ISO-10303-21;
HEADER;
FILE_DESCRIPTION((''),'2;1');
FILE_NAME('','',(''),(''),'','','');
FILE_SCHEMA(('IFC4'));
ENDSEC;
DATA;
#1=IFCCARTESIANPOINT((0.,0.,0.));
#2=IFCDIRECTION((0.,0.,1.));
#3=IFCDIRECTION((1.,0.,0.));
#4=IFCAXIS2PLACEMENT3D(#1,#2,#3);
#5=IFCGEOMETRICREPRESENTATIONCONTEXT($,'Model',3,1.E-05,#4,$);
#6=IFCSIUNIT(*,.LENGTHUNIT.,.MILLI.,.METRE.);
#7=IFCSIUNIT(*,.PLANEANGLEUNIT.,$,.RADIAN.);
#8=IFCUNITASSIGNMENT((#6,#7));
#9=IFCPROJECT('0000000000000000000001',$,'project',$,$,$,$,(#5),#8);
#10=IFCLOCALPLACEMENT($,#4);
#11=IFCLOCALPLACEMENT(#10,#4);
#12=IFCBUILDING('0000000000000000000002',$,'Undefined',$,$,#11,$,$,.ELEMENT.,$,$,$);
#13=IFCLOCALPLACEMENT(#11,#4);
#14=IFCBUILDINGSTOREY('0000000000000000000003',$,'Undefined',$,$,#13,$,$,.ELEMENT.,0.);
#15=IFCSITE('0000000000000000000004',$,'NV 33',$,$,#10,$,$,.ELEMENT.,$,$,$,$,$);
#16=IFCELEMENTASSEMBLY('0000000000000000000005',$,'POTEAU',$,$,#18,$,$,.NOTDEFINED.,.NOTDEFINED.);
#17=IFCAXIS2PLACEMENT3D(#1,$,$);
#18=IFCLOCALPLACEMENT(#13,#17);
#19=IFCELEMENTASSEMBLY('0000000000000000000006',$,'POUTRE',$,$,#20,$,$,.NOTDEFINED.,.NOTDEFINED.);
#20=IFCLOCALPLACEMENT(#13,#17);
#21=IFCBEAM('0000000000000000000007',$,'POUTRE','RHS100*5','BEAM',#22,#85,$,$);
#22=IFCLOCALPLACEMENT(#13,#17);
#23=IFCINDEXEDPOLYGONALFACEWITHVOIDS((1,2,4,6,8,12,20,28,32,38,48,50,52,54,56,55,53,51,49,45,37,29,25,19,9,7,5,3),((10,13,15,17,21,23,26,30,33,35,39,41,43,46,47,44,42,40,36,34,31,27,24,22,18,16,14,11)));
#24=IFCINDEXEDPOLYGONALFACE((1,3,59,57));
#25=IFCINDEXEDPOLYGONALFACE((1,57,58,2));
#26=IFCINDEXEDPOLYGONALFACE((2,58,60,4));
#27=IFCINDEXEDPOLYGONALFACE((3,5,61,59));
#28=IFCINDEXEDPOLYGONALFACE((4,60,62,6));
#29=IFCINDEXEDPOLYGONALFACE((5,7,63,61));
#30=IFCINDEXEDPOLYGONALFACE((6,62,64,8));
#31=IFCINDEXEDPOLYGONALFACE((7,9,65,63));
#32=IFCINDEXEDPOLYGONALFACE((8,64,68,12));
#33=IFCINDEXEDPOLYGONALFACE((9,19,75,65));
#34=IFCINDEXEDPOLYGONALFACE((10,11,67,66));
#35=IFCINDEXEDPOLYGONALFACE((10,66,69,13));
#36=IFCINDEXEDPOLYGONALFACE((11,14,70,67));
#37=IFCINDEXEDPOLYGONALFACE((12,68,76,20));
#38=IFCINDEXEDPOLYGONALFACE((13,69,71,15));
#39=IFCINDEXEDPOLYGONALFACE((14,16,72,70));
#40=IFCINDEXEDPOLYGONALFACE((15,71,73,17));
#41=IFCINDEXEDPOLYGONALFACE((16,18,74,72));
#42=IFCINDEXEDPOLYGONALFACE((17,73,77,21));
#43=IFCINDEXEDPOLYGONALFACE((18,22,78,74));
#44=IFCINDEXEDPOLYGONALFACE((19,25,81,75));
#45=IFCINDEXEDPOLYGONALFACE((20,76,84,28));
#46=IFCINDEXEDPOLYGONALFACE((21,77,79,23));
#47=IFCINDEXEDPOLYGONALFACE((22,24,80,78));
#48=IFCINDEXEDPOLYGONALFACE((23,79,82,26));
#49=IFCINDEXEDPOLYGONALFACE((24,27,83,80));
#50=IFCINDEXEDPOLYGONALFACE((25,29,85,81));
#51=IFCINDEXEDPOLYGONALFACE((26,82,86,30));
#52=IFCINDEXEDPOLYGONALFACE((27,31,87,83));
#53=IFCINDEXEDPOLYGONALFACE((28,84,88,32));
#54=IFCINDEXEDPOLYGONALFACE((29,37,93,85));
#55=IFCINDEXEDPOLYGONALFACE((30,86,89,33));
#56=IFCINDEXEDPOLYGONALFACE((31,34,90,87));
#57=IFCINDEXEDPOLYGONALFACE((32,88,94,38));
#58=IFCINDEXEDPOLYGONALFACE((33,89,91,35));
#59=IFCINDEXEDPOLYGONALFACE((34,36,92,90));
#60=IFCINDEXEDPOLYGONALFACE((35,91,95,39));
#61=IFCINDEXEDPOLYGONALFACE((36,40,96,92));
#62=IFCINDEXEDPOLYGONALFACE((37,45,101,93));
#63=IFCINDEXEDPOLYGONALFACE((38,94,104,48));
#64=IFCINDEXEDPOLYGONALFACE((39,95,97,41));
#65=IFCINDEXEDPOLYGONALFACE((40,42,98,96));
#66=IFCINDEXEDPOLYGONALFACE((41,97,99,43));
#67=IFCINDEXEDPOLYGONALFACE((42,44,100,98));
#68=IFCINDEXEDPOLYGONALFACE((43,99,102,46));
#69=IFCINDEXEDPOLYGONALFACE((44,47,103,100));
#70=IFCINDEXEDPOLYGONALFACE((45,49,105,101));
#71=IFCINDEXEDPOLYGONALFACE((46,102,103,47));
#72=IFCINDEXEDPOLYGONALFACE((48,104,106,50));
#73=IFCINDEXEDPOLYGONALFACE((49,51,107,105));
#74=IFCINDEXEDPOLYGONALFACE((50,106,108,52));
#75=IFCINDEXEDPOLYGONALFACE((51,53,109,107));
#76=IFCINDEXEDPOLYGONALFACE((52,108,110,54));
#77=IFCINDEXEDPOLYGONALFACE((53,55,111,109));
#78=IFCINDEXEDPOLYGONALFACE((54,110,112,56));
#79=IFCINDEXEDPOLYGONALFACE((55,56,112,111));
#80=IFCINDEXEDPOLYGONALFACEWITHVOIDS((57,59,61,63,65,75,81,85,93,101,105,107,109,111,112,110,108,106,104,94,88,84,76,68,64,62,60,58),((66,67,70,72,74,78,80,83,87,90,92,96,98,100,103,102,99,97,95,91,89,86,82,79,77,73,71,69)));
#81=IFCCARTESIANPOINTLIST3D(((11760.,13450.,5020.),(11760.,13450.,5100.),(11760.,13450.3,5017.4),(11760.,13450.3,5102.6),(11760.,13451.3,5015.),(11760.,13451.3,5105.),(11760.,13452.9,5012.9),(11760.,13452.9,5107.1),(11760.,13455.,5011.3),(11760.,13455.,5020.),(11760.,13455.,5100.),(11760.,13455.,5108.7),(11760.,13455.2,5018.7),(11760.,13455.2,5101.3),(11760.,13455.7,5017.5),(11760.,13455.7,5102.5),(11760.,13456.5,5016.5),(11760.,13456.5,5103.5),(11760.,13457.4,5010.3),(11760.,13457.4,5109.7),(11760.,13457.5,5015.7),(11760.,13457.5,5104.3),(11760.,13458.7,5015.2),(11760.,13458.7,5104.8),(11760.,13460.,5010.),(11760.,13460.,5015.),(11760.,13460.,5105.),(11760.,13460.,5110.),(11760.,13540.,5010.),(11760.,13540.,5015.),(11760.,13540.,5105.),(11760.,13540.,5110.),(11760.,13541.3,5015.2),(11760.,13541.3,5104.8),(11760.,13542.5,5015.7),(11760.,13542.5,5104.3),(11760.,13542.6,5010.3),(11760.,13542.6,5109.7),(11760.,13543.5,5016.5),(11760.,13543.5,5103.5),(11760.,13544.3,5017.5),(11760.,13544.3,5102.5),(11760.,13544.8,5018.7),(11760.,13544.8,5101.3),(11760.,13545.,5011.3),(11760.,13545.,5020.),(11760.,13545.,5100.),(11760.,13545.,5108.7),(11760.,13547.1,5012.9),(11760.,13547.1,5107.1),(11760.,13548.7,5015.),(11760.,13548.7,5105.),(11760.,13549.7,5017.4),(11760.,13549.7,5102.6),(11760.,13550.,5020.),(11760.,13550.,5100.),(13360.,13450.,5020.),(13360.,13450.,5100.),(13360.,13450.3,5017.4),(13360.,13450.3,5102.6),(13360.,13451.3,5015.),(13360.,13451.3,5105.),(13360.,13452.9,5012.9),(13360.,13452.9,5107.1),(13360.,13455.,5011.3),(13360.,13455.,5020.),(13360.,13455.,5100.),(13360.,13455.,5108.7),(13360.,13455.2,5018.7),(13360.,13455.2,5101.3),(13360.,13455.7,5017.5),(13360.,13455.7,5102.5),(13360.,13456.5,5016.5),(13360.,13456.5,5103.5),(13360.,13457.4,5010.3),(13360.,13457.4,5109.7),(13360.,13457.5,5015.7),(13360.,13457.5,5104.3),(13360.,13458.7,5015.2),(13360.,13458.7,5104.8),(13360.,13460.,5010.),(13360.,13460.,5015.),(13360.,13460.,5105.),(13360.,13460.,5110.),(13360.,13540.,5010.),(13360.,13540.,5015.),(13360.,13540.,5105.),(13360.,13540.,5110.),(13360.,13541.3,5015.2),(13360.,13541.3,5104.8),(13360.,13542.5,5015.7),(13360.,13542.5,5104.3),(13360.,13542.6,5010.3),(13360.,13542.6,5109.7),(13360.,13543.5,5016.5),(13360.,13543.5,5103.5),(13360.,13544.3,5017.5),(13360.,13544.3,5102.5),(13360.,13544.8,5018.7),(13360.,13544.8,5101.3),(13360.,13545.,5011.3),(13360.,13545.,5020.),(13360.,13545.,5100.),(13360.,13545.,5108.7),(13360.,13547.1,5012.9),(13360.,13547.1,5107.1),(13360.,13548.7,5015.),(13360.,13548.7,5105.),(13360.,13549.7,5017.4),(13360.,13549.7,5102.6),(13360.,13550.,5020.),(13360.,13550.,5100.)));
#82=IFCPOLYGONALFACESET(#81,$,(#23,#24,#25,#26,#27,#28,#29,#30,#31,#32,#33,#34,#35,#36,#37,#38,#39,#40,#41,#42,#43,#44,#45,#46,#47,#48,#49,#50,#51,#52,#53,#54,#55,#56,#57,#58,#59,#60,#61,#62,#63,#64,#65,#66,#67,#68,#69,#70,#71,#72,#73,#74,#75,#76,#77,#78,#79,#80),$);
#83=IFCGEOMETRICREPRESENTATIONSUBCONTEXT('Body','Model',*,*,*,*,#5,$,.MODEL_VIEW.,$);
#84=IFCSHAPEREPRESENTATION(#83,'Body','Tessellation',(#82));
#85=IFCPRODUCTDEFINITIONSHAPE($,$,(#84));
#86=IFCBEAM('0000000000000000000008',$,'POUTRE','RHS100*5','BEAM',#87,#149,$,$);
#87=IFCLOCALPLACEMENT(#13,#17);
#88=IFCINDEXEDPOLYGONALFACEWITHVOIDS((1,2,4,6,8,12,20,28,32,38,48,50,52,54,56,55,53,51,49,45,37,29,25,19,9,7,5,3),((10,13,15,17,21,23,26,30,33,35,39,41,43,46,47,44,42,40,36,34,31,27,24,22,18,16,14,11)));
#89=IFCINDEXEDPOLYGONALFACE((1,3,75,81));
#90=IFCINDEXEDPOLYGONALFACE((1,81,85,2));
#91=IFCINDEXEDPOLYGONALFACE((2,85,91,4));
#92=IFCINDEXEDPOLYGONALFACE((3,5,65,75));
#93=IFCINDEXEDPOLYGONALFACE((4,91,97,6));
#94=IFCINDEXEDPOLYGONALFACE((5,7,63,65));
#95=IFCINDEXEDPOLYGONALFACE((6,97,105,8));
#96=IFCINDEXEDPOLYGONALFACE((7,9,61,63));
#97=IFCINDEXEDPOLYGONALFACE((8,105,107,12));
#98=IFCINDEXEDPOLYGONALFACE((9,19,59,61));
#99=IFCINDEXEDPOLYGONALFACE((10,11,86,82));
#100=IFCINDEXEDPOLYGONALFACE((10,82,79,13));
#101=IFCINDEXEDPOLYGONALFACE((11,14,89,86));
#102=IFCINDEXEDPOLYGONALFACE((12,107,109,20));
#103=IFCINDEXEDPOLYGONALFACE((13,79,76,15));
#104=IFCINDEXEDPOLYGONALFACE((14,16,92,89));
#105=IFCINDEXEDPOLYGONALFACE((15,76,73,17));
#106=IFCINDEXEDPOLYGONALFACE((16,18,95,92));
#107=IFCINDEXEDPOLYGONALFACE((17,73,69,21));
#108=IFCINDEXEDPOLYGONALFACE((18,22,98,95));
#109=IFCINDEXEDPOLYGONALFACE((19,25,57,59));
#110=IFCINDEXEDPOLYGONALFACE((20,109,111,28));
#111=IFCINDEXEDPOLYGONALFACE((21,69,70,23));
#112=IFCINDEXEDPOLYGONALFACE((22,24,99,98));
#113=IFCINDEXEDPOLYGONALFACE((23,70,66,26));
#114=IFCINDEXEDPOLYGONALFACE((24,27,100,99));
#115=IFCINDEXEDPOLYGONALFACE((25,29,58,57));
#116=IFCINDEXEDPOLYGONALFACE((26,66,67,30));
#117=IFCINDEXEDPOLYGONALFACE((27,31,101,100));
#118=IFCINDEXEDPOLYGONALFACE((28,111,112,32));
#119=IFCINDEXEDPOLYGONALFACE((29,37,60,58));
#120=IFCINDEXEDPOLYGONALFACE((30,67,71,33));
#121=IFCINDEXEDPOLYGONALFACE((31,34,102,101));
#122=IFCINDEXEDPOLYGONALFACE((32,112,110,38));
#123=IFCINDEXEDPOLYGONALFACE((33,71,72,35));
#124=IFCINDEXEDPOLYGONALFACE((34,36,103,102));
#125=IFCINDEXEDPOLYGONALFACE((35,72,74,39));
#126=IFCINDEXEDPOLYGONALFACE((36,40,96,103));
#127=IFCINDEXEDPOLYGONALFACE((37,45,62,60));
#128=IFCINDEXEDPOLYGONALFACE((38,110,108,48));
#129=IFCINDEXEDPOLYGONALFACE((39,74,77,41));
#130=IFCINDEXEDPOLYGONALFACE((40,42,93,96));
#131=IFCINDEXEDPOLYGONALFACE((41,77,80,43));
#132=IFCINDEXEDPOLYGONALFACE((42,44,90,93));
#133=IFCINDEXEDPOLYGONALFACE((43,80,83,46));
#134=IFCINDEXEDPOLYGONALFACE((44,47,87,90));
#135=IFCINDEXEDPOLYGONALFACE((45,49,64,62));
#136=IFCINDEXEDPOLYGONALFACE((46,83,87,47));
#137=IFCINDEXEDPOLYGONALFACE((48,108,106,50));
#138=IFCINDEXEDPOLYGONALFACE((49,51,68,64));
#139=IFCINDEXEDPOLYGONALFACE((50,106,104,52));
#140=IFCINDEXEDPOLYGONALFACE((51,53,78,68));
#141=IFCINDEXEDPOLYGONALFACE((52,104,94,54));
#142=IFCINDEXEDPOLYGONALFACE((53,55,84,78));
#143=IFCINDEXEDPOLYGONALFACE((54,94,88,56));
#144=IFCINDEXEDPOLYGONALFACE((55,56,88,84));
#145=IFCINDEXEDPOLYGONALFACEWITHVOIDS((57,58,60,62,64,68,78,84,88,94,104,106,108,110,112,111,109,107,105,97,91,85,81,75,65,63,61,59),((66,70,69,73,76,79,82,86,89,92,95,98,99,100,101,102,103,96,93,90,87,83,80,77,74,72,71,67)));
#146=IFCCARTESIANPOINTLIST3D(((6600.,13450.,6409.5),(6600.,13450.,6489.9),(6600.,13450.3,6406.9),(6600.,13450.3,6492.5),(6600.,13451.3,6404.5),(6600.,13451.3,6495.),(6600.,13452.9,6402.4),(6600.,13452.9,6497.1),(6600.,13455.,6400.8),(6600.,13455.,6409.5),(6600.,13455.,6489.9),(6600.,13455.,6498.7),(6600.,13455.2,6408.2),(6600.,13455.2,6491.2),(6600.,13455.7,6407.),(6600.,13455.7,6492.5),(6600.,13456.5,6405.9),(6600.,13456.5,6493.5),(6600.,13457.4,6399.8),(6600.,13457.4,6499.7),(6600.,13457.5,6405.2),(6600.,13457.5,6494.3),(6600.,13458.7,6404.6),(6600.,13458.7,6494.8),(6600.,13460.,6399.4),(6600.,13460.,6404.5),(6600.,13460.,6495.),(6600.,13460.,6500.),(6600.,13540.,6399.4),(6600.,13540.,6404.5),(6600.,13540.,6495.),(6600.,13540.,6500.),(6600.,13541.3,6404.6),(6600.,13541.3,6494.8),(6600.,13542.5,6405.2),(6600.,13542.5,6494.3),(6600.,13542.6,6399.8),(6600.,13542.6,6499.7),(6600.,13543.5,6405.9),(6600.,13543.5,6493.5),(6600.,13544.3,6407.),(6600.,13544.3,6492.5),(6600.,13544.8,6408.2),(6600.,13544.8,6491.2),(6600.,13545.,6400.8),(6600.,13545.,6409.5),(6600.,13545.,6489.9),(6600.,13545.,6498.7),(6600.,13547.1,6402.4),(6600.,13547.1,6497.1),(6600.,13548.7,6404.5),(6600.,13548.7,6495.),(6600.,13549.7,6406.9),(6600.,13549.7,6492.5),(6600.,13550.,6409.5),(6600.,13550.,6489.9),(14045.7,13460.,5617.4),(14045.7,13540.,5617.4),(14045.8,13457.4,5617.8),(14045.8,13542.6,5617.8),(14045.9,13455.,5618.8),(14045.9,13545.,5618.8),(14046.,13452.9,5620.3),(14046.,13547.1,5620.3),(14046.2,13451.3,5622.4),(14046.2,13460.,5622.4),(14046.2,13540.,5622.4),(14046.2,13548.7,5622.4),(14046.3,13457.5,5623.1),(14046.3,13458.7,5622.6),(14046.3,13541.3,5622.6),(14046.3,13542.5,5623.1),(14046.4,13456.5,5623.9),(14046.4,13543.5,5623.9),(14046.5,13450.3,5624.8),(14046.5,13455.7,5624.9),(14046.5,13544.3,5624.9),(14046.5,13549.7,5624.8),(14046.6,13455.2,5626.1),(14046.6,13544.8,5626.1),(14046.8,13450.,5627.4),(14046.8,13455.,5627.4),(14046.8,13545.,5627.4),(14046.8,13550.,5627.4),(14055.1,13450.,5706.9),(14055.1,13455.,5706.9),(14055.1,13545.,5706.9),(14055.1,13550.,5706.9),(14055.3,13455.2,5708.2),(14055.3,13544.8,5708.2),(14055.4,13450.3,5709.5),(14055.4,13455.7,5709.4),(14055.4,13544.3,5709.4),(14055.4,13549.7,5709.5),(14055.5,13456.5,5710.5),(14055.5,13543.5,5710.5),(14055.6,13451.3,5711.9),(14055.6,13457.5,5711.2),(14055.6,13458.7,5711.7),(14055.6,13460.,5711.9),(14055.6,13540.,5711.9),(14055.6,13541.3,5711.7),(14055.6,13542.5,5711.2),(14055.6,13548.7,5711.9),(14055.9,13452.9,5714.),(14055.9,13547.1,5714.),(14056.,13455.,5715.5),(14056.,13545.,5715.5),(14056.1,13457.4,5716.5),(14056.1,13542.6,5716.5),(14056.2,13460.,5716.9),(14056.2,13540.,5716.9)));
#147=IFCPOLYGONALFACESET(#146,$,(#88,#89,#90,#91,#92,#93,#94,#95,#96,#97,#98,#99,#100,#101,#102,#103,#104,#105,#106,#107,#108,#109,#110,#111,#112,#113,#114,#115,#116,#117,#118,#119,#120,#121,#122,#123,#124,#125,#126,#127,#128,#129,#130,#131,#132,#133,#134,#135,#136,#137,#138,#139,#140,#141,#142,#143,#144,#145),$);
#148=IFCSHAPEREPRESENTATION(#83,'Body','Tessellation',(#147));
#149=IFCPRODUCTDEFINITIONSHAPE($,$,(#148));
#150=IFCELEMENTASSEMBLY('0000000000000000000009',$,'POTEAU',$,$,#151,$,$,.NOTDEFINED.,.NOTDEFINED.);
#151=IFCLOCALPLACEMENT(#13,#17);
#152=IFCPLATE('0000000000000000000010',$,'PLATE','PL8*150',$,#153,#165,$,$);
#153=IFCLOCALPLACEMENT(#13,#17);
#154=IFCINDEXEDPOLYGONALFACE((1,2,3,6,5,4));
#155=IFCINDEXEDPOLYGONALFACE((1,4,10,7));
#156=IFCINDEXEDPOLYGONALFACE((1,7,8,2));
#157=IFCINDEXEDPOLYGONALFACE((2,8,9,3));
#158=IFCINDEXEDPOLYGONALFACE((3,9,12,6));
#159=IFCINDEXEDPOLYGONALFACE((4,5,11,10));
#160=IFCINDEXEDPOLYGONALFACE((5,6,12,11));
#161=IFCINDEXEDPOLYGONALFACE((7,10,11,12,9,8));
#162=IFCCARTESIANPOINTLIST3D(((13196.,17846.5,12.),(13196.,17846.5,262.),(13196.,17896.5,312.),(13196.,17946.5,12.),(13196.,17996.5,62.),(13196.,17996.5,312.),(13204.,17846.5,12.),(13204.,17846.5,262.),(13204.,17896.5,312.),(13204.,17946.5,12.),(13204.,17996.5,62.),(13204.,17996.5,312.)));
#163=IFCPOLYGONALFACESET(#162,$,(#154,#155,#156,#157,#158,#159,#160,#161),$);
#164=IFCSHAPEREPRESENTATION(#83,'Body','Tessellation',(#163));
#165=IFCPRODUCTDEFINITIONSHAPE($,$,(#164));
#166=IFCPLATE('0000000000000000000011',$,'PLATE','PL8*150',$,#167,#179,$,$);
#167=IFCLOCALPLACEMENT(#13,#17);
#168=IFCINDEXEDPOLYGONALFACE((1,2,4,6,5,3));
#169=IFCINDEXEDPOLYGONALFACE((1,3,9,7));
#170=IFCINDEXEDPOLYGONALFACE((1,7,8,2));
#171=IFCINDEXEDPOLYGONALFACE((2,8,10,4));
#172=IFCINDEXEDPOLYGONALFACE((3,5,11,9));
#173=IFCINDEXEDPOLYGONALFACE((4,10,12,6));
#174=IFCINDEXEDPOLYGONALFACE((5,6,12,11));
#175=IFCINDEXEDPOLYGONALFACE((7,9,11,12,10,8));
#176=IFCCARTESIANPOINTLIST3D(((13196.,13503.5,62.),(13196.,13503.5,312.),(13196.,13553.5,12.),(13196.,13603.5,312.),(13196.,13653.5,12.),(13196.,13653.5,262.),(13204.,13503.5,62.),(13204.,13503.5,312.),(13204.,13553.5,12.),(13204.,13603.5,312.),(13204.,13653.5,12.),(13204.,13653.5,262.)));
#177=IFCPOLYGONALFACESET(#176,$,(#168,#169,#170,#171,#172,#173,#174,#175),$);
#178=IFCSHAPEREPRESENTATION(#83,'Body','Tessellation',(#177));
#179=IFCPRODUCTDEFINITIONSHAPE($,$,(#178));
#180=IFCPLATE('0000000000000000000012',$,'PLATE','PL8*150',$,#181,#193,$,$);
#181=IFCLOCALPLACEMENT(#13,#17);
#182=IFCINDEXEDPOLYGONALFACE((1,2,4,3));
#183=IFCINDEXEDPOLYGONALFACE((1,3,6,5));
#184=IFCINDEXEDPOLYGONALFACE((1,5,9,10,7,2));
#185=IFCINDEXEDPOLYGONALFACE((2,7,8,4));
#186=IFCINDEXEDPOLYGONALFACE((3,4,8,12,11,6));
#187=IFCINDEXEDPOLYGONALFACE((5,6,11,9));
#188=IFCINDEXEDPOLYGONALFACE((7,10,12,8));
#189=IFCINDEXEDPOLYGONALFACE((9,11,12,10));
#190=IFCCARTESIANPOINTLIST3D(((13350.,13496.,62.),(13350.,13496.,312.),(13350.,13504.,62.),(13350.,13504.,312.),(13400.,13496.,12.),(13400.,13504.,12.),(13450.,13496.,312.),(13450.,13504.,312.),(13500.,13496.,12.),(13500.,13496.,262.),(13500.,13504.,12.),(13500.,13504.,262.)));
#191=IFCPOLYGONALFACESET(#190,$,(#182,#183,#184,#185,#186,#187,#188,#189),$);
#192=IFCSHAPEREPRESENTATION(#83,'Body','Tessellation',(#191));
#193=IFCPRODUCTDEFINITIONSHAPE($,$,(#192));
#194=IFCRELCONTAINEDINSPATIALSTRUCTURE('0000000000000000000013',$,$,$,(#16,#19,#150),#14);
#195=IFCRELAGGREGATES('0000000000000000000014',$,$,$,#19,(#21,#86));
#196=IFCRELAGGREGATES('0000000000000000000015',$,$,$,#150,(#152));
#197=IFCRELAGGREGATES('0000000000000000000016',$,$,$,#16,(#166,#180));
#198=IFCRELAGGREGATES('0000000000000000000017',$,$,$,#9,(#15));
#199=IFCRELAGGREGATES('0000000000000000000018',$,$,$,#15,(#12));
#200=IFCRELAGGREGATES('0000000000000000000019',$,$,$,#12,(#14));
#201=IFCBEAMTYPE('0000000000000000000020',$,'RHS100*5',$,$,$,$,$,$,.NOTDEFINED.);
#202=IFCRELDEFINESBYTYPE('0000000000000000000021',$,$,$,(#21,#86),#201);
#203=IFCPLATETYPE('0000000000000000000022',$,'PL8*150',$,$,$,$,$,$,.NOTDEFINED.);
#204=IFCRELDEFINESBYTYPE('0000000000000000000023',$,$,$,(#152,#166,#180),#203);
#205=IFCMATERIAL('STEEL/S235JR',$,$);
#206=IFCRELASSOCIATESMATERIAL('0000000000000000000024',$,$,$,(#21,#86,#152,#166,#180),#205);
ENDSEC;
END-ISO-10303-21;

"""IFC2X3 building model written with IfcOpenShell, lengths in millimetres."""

from ifc_helpers import new_model, si_unit, frame, origin_with_axes, origin_2d_with_axis, place, context, subcontext, project, spatial, polyline, hollow_rectangle, outline, extrude, clip, halfspace, material, type_object, element, aggregate, save


model = new_model("IFC2X3")

# Units and contexts
model_context = context("Model", 3, precision=1e-05, world=origin_with_axes())
body_context = subcontext(model_context, "Body", "Model", "MODEL_VIEW")
ifc_project = project(units=[si_unit("LENGTHUNIT", "METRE", prefix="MILLI"), si_unit("PLANEANGLEUNIT", "RADIAN")], contexts=[model_context])

# Site, building, storey
site_placement = place(None, origin_with_axes())
site = spatial("IfcSite", under=ifc_project, at=site_placement, Name="NV 33", CompositionType="ELEMENT")
building_placement = place(site_placement, origin_with_axes())
building = spatial("IfcBuilding", under=site, at=building_placement, Name="Undefined", CompositionType="ELEMENT")
storey_placement = place(building_placement, origin_with_axes())
storey = spatial("IfcBuildingStorey", under=building, at=storey_placement, Name="Undefined", CompositionType="ELEMENT", Elevation=0.0)

# Element assembly
assembly_1_placement = place(storey_placement, origin_with_axes())
assembly_1 = element("IfcElementAssembly", 1, at=assembly_1_placement, inside=storey, Name="POTEAU", AssemblyPlace="NOTDEFINED", PredefinedType="NOTDEFINED")
ifc_material_1 = material(Name="STEEL/S235JR")

# Element assembly, beams
beam_type_1 = type_object("IfcBeamType", Name="RHS100*5", PredefinedType="NOTDEFINED")
assembly_2_placement = place(storey_placement, origin_with_axes())
assembly_2 = element("IfcElementAssembly", 2, at=assembly_2_placement, inside=storey, Name="POUTRE", AssemblyPlace="NOTDEFINED", PredefinedType="NOTDEFINED")
beam_1_placement = place(assembly_2_placement, frame((13360.0, 13500.0, 5060.0), z_axis=(0.0, -1.0, 0.0), x_axis=(-1.0, 0.0, 0.0)))
beam_1 = element("IfcBeam", 3, at=beam_1_placement, type_object=beam_type_1, material=ifc_material_1, Name="POUTRE", Description="RHS100*5", ObjectType="BEAM", context=body_context, shape_type="SweptSolid", body=[
    extrude(hollow_rectangle(XDim=100.0, YDim=100.0, WallThickness=5.0, InnerFilletRadius=5.0, OuterFilletRadius=10.0, at=origin_2d_with_axis()), frame((1600.0, 0.0, 0.0), z_axis=(-1.0, 0.0, 0.0), x_axis=(0.0, -1.0, 0.0)), (0.0, 0.0, 1.0), 1600.0),
])
beam_2_placement = place(assembly_2_placement, frame((14050.9, 13500.0, 5667.2), z_axis=(-0.104455, 0.0, -0.99453), x_axis=(-0.99453, 0.0, 0.104455)))
beam_2 = element("IfcBeam", 4, at=beam_2_placement, type_object=beam_type_1, material=ifc_material_1, Name="POUTRE", Description="RHS100*5", ObjectType="BEAM", context=body_context, shape_type="Clipping", body=[
    clip(extrude(hollow_rectangle(XDim=100.0, YDim=100.0, WallThickness=5.0, InnerFilletRadius=5.0, OuterFilletRadius=10.0, at=origin_2d_with_axis()), frame((7527.2, 0.0, 0.0), z_axis=(-1.0, 0.0, 0.0), x_axis=(0.0, -1.0, 0.0)), (0.0, 0.0, 1.0), 7527.2), halfspace(frame((7497.2, 50.0, -50.0), z_axis=(0.99453, 0.0, 0.104455), x_axis=(0.0, -1.0, 0.0)), False)),
])
aggregate(assembly_2, [beam_1, beam_2])

# Element assembly, plate
assembly_3_placement = place(storey_placement, origin_with_axes())
assembly_3 = element("IfcElementAssembly", 5, at=assembly_3_placement, inside=storey, Name="POTEAU", AssemblyPlace="NOTDEFINED", PredefinedType="NOTDEFINED")
plate_type_1 = type_object("IfcPlateType", Name="PL8*150", PredefinedType="NOTDEFINED")
plate_1_placement = place(assembly_3_placement, frame((13200.0, 17996.5, 12.0), z_axis=(-1.0, 0.0, 0.0), x_axis=(0.0, -1.0, 0.0)))
plate_1 = element("IfcPlate", 6, at=plate_1_placement, type_object=plate_type_1, material=ifc_material_1, Name="PLATE", Description="PL8*150", context=body_context, shape_type="SweptSolid", body=[
    extrude(outline(polyline([(0.0, 50.0), (50.0, 0.0), (150.0, 0.0), (150.0, 250.0), (100.0, 300.0), (0.0, 300.0), (0.0, 50.0)])), frame((0.0, 0.0, -4.0), z_axis=(0.0, 0.0, 1.0), x_axis=(1.0, 0.0, 0.0)), (0.0, 0.0, 1.0), 8.0),
])

# Plates
plate_2_placement = place(assembly_1_placement, frame((13200.0, 13503.5, 12.0), z_axis=(1.0, 0.0, 0.0), x_axis=(0.0, 1.0, 0.0)))
plate_2 = element("IfcPlate", 7, at=plate_2_placement, type_object=plate_type_1, material=ifc_material_1, Name="PLATE", Description="PL8*150", context=body_context, shape_type="SweptSolid", body=[
    extrude(outline(polyline([(0.0, 50.0), (50.0, 0.0), (150.0, 0.0), (150.0, 250.0), (100.0, 300.0), (0.0, 300.0), (0.0, 50.0)])), frame((0.0, 0.0, -4.0), z_axis=(0.0, 0.0, 1.0), x_axis=(1.0, 0.0, 0.0)), (0.0, 0.0, 1.0), 8.0),
])
plate_3_placement = place(assembly_1_placement, frame((13350.0, 13500.0, 12.0), z_axis=(0.0, -1.0, 0.0), x_axis=(1.0, 0.0, 0.0)))
plate_3 = element("IfcPlate", 8, at=plate_3_placement, type_object=plate_type_1, material=ifc_material_1, Name="PLATE", Description="PL8*150", context=body_context, shape_type="SweptSolid", body=[
    extrude(outline(polyline([(0.0, 50.0), (50.0, 0.0), (150.0, 0.0), (150.0, 250.0), (100.0, 300.0), (0.0, 300.0), (0.0, 50.0)])), frame((0.0, 0.0, -4.0), z_axis=(0.0, 0.0, 1.0), x_axis=(1.0, 0.0, 0.0)), (0.0, 0.0, 1.0), 8.0),
])
aggregate(assembly_3, [plate_1])

aggregate(assembly_1, [plate_2, plate_3])

save(model, "model.ifc")
